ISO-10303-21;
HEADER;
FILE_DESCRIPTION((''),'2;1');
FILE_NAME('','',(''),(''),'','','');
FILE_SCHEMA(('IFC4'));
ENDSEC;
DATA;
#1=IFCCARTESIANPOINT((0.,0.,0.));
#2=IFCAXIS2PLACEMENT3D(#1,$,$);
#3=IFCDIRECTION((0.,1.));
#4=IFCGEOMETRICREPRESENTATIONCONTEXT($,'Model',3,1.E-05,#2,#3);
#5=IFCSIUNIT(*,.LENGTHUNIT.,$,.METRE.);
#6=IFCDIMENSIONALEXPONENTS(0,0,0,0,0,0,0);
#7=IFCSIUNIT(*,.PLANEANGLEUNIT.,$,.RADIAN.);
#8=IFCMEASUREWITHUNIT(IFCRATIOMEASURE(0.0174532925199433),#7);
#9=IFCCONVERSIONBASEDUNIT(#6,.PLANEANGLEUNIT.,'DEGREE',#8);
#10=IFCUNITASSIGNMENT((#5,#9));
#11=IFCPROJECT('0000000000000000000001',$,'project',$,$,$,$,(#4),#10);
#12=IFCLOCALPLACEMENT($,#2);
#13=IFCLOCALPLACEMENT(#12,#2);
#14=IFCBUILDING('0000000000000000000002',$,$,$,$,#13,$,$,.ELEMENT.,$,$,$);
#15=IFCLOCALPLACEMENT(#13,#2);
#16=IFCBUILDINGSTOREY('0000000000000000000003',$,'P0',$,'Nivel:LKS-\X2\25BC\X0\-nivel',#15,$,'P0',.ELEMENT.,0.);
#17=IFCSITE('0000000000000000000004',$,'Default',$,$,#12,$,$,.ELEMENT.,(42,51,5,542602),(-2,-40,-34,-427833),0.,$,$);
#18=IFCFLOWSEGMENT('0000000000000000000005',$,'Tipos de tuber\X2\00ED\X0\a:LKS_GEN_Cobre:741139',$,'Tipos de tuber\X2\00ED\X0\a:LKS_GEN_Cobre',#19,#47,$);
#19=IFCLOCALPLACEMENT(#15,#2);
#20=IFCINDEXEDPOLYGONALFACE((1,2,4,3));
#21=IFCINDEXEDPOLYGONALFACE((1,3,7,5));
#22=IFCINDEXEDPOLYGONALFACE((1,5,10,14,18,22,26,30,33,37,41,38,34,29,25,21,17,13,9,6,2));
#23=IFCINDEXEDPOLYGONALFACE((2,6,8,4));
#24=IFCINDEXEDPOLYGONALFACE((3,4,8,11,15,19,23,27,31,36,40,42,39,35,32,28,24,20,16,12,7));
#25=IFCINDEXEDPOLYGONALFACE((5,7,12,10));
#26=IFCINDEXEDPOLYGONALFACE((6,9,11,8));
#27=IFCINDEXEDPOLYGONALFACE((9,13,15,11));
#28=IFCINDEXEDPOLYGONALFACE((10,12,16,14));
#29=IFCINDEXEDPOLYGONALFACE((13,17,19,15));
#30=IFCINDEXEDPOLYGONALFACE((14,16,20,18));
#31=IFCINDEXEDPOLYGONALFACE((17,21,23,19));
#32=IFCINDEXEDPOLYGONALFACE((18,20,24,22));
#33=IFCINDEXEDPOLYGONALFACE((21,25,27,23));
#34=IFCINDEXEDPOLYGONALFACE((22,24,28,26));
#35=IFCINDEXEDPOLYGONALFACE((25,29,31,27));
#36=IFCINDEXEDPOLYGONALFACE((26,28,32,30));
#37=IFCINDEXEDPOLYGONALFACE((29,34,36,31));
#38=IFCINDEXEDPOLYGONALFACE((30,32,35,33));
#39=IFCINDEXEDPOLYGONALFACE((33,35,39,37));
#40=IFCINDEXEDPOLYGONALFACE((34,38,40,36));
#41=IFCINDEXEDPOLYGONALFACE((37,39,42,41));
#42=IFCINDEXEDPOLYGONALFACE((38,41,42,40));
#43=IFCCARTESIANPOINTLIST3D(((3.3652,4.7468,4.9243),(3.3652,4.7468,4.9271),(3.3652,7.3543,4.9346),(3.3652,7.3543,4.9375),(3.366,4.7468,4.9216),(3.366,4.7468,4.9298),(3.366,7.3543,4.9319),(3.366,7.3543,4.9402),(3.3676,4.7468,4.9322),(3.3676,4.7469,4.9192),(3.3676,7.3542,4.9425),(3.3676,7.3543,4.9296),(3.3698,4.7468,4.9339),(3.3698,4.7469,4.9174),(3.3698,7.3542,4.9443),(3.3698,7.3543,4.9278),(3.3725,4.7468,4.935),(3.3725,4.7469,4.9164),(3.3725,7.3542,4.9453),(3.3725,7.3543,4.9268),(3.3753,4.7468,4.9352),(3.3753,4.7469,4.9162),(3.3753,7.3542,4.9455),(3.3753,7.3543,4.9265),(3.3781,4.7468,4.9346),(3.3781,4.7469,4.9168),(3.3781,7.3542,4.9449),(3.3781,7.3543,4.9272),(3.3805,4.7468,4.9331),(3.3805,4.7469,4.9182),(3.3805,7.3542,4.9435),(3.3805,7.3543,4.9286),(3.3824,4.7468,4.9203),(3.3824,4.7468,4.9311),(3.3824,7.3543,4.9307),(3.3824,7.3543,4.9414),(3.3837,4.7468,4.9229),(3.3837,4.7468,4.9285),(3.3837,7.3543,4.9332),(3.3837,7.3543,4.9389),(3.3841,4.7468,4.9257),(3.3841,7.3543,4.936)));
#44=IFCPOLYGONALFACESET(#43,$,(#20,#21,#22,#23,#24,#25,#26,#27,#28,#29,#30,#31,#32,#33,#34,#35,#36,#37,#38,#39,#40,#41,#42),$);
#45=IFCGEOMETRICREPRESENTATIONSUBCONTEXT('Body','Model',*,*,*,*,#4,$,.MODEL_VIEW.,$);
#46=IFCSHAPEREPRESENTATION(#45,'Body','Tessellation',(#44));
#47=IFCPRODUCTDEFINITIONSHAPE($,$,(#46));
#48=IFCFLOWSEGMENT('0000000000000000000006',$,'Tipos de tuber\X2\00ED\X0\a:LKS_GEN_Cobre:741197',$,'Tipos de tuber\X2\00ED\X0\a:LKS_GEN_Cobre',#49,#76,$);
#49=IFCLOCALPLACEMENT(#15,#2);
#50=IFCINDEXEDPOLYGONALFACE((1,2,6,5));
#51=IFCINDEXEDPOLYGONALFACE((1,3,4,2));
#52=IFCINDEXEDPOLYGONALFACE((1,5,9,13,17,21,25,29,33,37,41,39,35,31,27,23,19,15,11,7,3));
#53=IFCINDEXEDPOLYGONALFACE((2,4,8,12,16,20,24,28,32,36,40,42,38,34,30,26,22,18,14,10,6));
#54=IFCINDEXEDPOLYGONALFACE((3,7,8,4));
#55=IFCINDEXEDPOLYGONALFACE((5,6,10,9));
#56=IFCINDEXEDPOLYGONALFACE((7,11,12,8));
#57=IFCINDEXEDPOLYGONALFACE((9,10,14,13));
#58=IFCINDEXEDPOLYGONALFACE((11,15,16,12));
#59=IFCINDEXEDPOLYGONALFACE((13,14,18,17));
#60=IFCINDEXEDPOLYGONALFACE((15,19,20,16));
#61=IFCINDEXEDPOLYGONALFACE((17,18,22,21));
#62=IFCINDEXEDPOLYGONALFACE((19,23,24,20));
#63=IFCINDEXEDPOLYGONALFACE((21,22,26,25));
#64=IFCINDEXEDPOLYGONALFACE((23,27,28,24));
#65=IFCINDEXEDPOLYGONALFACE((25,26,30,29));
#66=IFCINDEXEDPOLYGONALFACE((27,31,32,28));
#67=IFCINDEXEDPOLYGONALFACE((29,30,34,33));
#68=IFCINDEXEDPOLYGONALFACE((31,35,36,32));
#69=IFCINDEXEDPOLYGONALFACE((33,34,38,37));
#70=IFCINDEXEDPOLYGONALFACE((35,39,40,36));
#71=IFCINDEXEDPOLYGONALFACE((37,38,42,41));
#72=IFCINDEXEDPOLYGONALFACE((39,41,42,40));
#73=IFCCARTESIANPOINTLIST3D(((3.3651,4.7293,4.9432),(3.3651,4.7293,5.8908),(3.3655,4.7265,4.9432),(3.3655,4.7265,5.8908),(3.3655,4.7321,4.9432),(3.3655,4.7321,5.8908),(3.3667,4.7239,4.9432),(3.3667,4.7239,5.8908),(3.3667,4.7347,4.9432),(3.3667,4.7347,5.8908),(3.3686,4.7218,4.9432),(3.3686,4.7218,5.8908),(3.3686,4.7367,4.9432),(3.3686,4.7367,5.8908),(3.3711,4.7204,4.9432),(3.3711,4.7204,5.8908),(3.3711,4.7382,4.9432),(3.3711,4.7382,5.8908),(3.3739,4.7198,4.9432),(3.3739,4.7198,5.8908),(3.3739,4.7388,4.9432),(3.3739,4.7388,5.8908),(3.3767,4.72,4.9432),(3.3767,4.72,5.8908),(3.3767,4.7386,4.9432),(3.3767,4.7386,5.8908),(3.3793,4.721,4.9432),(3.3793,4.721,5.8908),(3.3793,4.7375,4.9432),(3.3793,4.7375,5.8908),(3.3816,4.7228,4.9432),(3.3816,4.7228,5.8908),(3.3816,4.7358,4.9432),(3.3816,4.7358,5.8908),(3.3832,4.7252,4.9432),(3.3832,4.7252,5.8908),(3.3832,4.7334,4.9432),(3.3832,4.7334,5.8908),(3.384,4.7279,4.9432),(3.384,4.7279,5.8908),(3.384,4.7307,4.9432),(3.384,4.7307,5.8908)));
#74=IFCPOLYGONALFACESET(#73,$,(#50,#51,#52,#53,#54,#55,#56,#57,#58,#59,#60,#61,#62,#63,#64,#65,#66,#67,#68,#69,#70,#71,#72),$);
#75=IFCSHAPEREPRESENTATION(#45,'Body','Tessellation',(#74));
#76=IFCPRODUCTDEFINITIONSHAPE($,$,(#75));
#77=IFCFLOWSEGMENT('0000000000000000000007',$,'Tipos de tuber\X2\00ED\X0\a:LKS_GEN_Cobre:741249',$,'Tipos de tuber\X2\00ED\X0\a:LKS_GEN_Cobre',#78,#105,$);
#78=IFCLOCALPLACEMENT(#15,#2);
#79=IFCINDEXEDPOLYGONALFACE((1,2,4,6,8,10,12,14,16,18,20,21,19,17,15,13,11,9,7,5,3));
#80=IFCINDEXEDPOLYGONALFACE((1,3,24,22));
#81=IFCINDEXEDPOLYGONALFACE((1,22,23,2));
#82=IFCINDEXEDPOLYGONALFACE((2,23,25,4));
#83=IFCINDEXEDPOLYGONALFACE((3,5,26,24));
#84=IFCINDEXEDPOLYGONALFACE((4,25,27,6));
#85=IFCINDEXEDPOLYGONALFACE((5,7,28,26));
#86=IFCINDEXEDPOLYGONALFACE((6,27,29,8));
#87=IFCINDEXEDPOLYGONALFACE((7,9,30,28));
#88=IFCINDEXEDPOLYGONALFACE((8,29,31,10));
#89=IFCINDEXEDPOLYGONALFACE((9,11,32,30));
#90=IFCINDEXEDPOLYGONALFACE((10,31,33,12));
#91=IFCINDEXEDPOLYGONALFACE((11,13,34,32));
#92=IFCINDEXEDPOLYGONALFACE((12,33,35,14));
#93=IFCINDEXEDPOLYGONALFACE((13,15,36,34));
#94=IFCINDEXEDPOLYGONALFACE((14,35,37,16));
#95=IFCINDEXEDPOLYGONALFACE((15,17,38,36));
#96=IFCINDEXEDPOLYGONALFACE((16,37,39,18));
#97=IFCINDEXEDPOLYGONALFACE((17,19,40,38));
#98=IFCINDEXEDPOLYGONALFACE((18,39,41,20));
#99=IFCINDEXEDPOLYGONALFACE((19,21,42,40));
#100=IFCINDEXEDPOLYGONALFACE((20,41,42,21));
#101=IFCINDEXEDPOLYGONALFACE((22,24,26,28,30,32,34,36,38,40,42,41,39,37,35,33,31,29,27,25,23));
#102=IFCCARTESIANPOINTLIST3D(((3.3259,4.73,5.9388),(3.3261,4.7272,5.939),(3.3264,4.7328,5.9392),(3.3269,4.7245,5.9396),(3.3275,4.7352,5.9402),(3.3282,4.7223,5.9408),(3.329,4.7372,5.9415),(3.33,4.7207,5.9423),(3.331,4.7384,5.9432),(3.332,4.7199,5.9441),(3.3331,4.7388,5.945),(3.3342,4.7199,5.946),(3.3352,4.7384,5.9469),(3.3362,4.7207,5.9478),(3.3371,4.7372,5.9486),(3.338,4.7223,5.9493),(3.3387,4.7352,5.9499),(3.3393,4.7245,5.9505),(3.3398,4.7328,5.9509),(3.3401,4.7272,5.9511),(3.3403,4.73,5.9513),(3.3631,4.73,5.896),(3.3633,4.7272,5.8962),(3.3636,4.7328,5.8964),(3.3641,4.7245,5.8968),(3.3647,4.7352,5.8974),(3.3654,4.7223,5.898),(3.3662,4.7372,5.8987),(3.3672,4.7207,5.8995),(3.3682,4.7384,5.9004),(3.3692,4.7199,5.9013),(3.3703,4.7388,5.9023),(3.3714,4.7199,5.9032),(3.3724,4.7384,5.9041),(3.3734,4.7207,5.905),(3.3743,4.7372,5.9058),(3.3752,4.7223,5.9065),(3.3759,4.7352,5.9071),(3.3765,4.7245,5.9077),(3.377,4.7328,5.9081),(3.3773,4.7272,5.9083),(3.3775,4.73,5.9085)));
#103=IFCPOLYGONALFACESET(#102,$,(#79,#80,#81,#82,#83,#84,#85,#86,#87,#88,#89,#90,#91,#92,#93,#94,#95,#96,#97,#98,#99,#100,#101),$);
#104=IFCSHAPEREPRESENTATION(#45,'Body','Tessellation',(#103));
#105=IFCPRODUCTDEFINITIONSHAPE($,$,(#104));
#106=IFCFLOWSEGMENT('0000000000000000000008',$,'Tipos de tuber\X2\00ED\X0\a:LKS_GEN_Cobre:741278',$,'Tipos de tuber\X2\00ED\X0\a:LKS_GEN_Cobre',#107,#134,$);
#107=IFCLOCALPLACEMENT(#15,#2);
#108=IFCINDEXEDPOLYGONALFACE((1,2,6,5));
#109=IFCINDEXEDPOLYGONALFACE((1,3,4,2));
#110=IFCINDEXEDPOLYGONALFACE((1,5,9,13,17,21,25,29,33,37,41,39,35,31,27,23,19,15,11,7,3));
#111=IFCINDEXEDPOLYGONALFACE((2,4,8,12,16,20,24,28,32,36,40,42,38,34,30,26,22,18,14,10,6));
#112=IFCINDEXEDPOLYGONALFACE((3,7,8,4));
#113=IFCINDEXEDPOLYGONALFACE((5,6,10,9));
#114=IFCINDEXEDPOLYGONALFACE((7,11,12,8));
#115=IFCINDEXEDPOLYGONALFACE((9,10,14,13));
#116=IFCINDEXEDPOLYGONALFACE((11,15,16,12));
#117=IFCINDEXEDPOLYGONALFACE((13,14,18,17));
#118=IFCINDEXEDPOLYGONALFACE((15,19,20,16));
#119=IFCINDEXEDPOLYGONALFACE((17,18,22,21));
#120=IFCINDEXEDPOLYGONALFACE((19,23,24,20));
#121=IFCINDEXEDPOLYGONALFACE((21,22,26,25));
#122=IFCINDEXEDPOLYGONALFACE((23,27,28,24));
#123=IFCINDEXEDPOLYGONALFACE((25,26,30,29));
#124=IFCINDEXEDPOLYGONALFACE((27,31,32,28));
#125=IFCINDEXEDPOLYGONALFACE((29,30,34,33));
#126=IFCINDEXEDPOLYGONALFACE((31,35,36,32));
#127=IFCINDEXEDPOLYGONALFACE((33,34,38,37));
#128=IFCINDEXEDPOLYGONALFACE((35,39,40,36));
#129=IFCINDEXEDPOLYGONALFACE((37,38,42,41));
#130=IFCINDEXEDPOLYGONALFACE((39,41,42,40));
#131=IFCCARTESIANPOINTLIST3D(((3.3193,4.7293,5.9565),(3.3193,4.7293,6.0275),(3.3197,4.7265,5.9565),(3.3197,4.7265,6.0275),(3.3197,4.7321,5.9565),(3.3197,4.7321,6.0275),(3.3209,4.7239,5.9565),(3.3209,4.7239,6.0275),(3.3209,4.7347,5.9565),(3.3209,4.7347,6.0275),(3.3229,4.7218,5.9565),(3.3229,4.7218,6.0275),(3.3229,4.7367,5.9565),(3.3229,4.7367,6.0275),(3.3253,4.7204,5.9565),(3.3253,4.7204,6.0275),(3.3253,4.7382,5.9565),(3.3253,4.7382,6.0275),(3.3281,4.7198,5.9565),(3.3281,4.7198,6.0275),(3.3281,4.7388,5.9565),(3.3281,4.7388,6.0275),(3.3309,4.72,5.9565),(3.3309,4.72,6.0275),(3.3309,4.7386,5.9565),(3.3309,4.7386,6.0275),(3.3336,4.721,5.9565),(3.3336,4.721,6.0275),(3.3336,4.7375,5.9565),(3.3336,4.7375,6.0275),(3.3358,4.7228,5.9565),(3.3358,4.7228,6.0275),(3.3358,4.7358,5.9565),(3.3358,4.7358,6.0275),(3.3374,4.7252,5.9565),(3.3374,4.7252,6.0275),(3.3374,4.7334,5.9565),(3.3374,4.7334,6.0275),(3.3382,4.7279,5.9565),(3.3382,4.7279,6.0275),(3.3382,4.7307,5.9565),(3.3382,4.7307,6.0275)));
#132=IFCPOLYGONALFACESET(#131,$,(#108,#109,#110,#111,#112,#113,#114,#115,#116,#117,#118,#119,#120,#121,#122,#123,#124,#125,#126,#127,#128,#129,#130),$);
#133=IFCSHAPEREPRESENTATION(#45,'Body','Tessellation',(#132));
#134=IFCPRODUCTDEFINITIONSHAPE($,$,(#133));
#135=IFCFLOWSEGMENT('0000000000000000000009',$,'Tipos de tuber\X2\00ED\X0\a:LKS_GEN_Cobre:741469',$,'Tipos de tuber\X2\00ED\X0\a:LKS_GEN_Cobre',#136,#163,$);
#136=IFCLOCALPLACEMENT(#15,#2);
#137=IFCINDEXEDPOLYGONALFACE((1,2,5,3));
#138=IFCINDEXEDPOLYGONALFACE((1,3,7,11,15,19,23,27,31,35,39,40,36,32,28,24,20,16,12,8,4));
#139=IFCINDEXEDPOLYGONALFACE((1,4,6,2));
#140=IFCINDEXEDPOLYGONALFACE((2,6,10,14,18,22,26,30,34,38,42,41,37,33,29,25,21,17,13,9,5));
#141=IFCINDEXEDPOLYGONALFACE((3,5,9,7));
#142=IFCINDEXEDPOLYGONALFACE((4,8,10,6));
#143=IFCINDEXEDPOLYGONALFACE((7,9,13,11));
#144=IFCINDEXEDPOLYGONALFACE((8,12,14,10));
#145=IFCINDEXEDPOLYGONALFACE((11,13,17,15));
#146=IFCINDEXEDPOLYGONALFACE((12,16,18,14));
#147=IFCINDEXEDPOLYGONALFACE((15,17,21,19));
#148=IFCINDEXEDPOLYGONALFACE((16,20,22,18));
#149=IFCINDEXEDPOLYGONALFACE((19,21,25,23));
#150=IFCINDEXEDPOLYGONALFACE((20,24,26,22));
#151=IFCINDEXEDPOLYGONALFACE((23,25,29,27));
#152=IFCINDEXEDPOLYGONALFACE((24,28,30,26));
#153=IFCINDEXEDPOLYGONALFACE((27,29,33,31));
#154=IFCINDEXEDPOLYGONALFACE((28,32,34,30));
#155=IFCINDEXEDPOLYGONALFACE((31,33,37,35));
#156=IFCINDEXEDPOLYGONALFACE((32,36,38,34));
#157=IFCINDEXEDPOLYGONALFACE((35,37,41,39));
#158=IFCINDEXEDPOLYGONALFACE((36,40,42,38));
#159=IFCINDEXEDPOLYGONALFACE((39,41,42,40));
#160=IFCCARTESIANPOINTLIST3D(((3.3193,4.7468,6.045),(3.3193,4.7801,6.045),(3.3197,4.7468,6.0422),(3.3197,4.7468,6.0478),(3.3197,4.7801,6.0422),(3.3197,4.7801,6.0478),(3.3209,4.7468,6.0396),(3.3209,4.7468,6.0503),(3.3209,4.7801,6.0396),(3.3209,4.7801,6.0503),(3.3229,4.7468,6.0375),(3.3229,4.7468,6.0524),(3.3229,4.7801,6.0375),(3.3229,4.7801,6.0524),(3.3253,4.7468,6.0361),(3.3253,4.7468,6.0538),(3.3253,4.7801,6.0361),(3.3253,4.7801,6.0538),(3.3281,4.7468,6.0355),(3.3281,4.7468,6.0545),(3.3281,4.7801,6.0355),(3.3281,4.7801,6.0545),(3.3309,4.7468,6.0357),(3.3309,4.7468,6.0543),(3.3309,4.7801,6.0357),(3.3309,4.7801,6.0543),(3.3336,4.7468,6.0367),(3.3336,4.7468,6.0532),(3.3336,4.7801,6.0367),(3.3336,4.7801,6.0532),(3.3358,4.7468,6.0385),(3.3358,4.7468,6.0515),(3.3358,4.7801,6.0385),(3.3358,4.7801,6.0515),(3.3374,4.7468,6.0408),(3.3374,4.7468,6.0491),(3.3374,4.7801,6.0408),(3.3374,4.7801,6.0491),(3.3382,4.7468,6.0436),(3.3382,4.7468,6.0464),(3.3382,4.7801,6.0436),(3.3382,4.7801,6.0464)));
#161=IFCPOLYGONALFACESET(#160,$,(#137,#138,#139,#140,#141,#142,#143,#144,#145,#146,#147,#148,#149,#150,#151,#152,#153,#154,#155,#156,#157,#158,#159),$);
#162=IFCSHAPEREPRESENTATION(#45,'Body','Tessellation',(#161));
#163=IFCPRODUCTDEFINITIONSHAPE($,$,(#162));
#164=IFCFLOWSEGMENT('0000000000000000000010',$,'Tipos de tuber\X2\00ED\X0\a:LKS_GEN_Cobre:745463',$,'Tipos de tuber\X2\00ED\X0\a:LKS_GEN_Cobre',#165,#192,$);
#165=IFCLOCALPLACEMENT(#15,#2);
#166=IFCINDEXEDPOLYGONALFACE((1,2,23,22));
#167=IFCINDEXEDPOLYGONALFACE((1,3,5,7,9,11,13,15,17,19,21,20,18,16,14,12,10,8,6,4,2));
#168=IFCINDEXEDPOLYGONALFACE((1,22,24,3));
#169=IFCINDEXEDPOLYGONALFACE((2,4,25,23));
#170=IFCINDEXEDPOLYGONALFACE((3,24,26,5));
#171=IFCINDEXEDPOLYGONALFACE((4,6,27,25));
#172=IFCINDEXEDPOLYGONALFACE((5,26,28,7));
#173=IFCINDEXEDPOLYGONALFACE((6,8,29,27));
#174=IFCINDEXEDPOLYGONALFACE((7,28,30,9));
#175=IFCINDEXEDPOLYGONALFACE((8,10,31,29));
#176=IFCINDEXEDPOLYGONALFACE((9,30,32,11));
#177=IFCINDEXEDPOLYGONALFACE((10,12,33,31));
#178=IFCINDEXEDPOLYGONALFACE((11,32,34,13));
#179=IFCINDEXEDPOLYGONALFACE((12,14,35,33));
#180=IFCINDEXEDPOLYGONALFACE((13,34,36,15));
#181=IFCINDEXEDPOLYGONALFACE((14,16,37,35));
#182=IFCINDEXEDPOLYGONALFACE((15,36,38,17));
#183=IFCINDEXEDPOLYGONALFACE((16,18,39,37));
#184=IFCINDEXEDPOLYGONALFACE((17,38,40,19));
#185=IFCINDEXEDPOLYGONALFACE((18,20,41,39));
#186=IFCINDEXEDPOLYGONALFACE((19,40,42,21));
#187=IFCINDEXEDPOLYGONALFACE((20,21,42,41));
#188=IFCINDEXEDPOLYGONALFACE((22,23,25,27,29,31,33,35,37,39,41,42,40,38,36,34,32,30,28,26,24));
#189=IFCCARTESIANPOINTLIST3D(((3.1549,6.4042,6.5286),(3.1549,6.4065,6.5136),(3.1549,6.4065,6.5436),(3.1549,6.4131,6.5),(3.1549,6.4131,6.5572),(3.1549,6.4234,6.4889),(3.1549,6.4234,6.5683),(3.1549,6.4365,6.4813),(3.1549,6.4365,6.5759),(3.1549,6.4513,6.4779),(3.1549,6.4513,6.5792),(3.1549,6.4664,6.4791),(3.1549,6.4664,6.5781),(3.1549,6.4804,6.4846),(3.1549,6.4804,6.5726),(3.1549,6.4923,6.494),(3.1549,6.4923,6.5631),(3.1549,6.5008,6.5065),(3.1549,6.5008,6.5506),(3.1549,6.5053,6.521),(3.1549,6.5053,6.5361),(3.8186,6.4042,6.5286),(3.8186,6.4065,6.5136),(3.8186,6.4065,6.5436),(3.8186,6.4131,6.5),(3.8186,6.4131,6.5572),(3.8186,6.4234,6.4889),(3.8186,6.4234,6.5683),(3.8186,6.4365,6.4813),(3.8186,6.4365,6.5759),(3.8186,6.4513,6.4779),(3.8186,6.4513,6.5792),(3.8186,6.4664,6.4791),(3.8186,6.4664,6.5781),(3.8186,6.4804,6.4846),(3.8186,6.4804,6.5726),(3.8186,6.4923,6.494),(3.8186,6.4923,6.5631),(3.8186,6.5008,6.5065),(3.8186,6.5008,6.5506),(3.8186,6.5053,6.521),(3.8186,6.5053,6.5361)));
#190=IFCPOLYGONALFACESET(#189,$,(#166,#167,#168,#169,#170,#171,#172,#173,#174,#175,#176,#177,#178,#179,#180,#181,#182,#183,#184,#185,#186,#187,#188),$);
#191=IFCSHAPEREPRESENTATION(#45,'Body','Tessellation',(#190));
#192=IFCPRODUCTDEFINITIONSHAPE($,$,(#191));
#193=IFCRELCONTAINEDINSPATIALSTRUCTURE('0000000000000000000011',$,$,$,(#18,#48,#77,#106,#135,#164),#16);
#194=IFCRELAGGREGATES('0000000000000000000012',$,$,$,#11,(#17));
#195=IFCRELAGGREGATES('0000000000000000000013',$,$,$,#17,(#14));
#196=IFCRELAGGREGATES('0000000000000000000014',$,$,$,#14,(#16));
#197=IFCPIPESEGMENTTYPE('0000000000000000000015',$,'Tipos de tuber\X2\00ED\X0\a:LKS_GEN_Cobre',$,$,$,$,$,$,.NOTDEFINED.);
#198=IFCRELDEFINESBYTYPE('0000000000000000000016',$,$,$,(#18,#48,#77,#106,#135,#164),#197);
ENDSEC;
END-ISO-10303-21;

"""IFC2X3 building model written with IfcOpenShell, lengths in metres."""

from ifc_helpers import new_model, entity, si_unit, converted_unit, direction, frame, frame_2d, origin, origin_2d_with_axis, place, context, subcontext, project, spatial, circle, extrude, type_object, element, save


model = new_model("IFC2X3")

# Units and contexts
model_context = context("Model", 3, precision=1e-05, world=origin(), true_north=direction((0.0, 1.0)))
body_context = subcontext(model_context, "Body", "Model", "MODEL_VIEW")
ifc_project = project(units=[si_unit("LENGTHUNIT", "METRE"), converted_unit("PLANEANGLEUNIT", "DEGREE", entity("IfcRatioMeasure", 0.0174532925199433), si_unit("PLANEANGLEUNIT", "RADIAN"), dimensions=[0, 0, 0, 0, 0, 0, 0])], contexts=[model_context])

# Site, building, storey
site_placement = place(None, origin())
site = spatial("IfcSite", under=ifc_project, at=site_placement, Name="Default", CompositionType="ELEMENT", RefLatitude=(42, 51, 5, 542602), RefLongitude=(-2, -40, -34, -427833), RefElevation=0.0)
building_placement = place(site_placement, origin())
building = spatial("IfcBuilding", under=site, at=building_placement, CompositionType="ELEMENT")
storey_placement = place(building_placement, origin())
storey = spatial("IfcBuildingStorey", under=building, at=storey_placement, Name="P0", ObjectType="Nivel:LKS-▼-nivel", LongName="P0", CompositionType="ELEMENT", Elevation=0.0)

# Flow segments
pipe_segment_type = type_object("IfcPipeSegmentType", Name="Tipos de tubería:LKS_GEN_Cobre", PredefinedType="NOTDEFINED")
flow_segment_1_placement = place(storey_placement, origin())
element("IfcFlowSegment", 1, at=flow_segment_1_placement, inside=storey, type_object=pipe_segment_type, Name="Tipos de tubería:LKS_GEN_Cobre:741139", ObjectType="Tipos de tubería:LKS_GEN_Cobre", context=body_context, shape_type="SweptSolid", body=[
    extrude(circle(Radius=0.0095, at=origin_2d_with_axis()), frame((3.3746, 4.7468, 4.9257), z_axis=(0.0, 0.999992, 0.003969), x_axis=(1.0, 0.0, 0.0)), (0.0, 0.0, 1.0), 2.6075),
])
flow_segment_2_placement = place(storey_placement, origin())
element("IfcFlowSegment", 2, at=flow_segment_2_placement, inside=storey, type_object=pipe_segment_type, Name="Tipos de tubería:LKS_GEN_Cobre:741197", ObjectType="Tipos de tubería:LKS_GEN_Cobre", context=body_context, shape_type="SweptSolid", body=[
    extrude(circle(Radius=0.0095, at=origin_2d_with_axis()), frame((3.3746, 4.7293, 4.9432), z_axis=(0.0, 0.0, 1.0), x_axis=(-1.0, 0.0, 0.0)), (0.0, 0.0, 1.0), 0.9476),
])
flow_segment_3_placement = place(storey_placement, origin())
element("IfcFlowSegment", 3, at=flow_segment_3_placement, inside=storey, type_object=pipe_segment_type, Name="Tipos de tubería:LKS_GEN_Cobre:741249", ObjectType="Tipos de tubería:LKS_GEN_Cobre", context=body_context, shape_type="SweptSolid", body=[
    extrude(circle(Radius=0.0095, at=frame_2d((0.0, 0.0), x_axis=(1.0, 0.0))), frame((3.3331, 4.7293, 5.945), z_axis=(0.656059, 0.0, -0.75471), x_axis=(0.0, 1.0, 0.0)), (0.0, 0.0, 1.0), 0.0567),
])
flow_segment_4_placement = place(storey_placement, origin())
element("IfcFlowSegment", 4, at=flow_segment_4_placement, inside=storey, type_object=pipe_segment_type, Name="Tipos de tubería:LKS_GEN_Cobre:741278", ObjectType="Tipos de tubería:LKS_GEN_Cobre", context=body_context, shape_type="SweptSolid", body=[
    extrude(circle(Radius=0.0095, at=origin_2d_with_axis()), frame((3.3288, 4.7293, 5.9565), z_axis=(0.0, 0.0, 1.0), x_axis=(-1.0, 0.0, 0.0)), (0.0, 0.0, 1.0), 0.071),
])
flow_segment_5_placement = place(storey_placement, origin())
element("IfcFlowSegment", 5, at=flow_segment_5_placement, inside=storey, type_object=pipe_segment_type, Name="Tipos de tubería:LKS_GEN_Cobre:741469", ObjectType="Tipos de tubería:LKS_GEN_Cobre", context=body_context, shape_type="SweptSolid", body=[
    extrude(circle(Radius=0.0095, at=frame_2d((0.0, 0.0), x_axis=(1.0, 0.0))), frame((3.3288, 4.7468, 6.045), z_axis=(0.0, 1.0, 0.0), x_axis=(-1.0, 0.0, 0.0)), (0.0, 0.0, 1.0), 0.0333),
])
flow_segment_6_placement = place(storey_placement, origin())
element("IfcFlowSegment", 6, at=flow_segment_6_placement, inside=storey, type_object=pipe_segment_type, Name="Tipos de tubería:LKS_GEN_Cobre:745463", ObjectType="Tipos de tubería:LKS_GEN_Cobre", context=body_context, shape_type="SweptSolid", body=[
    extrude(circle(Radius=0.0508, at=origin_2d_with_axis()), frame((3.1549, 6.455, 6.5286), z_axis=(1.0, 0.0, 0.0), x_axis=(0.0, -1.0, 0.0)), (0.0, 0.0, 1.0), 0.6637),
])

save(model, "model.ifc")
